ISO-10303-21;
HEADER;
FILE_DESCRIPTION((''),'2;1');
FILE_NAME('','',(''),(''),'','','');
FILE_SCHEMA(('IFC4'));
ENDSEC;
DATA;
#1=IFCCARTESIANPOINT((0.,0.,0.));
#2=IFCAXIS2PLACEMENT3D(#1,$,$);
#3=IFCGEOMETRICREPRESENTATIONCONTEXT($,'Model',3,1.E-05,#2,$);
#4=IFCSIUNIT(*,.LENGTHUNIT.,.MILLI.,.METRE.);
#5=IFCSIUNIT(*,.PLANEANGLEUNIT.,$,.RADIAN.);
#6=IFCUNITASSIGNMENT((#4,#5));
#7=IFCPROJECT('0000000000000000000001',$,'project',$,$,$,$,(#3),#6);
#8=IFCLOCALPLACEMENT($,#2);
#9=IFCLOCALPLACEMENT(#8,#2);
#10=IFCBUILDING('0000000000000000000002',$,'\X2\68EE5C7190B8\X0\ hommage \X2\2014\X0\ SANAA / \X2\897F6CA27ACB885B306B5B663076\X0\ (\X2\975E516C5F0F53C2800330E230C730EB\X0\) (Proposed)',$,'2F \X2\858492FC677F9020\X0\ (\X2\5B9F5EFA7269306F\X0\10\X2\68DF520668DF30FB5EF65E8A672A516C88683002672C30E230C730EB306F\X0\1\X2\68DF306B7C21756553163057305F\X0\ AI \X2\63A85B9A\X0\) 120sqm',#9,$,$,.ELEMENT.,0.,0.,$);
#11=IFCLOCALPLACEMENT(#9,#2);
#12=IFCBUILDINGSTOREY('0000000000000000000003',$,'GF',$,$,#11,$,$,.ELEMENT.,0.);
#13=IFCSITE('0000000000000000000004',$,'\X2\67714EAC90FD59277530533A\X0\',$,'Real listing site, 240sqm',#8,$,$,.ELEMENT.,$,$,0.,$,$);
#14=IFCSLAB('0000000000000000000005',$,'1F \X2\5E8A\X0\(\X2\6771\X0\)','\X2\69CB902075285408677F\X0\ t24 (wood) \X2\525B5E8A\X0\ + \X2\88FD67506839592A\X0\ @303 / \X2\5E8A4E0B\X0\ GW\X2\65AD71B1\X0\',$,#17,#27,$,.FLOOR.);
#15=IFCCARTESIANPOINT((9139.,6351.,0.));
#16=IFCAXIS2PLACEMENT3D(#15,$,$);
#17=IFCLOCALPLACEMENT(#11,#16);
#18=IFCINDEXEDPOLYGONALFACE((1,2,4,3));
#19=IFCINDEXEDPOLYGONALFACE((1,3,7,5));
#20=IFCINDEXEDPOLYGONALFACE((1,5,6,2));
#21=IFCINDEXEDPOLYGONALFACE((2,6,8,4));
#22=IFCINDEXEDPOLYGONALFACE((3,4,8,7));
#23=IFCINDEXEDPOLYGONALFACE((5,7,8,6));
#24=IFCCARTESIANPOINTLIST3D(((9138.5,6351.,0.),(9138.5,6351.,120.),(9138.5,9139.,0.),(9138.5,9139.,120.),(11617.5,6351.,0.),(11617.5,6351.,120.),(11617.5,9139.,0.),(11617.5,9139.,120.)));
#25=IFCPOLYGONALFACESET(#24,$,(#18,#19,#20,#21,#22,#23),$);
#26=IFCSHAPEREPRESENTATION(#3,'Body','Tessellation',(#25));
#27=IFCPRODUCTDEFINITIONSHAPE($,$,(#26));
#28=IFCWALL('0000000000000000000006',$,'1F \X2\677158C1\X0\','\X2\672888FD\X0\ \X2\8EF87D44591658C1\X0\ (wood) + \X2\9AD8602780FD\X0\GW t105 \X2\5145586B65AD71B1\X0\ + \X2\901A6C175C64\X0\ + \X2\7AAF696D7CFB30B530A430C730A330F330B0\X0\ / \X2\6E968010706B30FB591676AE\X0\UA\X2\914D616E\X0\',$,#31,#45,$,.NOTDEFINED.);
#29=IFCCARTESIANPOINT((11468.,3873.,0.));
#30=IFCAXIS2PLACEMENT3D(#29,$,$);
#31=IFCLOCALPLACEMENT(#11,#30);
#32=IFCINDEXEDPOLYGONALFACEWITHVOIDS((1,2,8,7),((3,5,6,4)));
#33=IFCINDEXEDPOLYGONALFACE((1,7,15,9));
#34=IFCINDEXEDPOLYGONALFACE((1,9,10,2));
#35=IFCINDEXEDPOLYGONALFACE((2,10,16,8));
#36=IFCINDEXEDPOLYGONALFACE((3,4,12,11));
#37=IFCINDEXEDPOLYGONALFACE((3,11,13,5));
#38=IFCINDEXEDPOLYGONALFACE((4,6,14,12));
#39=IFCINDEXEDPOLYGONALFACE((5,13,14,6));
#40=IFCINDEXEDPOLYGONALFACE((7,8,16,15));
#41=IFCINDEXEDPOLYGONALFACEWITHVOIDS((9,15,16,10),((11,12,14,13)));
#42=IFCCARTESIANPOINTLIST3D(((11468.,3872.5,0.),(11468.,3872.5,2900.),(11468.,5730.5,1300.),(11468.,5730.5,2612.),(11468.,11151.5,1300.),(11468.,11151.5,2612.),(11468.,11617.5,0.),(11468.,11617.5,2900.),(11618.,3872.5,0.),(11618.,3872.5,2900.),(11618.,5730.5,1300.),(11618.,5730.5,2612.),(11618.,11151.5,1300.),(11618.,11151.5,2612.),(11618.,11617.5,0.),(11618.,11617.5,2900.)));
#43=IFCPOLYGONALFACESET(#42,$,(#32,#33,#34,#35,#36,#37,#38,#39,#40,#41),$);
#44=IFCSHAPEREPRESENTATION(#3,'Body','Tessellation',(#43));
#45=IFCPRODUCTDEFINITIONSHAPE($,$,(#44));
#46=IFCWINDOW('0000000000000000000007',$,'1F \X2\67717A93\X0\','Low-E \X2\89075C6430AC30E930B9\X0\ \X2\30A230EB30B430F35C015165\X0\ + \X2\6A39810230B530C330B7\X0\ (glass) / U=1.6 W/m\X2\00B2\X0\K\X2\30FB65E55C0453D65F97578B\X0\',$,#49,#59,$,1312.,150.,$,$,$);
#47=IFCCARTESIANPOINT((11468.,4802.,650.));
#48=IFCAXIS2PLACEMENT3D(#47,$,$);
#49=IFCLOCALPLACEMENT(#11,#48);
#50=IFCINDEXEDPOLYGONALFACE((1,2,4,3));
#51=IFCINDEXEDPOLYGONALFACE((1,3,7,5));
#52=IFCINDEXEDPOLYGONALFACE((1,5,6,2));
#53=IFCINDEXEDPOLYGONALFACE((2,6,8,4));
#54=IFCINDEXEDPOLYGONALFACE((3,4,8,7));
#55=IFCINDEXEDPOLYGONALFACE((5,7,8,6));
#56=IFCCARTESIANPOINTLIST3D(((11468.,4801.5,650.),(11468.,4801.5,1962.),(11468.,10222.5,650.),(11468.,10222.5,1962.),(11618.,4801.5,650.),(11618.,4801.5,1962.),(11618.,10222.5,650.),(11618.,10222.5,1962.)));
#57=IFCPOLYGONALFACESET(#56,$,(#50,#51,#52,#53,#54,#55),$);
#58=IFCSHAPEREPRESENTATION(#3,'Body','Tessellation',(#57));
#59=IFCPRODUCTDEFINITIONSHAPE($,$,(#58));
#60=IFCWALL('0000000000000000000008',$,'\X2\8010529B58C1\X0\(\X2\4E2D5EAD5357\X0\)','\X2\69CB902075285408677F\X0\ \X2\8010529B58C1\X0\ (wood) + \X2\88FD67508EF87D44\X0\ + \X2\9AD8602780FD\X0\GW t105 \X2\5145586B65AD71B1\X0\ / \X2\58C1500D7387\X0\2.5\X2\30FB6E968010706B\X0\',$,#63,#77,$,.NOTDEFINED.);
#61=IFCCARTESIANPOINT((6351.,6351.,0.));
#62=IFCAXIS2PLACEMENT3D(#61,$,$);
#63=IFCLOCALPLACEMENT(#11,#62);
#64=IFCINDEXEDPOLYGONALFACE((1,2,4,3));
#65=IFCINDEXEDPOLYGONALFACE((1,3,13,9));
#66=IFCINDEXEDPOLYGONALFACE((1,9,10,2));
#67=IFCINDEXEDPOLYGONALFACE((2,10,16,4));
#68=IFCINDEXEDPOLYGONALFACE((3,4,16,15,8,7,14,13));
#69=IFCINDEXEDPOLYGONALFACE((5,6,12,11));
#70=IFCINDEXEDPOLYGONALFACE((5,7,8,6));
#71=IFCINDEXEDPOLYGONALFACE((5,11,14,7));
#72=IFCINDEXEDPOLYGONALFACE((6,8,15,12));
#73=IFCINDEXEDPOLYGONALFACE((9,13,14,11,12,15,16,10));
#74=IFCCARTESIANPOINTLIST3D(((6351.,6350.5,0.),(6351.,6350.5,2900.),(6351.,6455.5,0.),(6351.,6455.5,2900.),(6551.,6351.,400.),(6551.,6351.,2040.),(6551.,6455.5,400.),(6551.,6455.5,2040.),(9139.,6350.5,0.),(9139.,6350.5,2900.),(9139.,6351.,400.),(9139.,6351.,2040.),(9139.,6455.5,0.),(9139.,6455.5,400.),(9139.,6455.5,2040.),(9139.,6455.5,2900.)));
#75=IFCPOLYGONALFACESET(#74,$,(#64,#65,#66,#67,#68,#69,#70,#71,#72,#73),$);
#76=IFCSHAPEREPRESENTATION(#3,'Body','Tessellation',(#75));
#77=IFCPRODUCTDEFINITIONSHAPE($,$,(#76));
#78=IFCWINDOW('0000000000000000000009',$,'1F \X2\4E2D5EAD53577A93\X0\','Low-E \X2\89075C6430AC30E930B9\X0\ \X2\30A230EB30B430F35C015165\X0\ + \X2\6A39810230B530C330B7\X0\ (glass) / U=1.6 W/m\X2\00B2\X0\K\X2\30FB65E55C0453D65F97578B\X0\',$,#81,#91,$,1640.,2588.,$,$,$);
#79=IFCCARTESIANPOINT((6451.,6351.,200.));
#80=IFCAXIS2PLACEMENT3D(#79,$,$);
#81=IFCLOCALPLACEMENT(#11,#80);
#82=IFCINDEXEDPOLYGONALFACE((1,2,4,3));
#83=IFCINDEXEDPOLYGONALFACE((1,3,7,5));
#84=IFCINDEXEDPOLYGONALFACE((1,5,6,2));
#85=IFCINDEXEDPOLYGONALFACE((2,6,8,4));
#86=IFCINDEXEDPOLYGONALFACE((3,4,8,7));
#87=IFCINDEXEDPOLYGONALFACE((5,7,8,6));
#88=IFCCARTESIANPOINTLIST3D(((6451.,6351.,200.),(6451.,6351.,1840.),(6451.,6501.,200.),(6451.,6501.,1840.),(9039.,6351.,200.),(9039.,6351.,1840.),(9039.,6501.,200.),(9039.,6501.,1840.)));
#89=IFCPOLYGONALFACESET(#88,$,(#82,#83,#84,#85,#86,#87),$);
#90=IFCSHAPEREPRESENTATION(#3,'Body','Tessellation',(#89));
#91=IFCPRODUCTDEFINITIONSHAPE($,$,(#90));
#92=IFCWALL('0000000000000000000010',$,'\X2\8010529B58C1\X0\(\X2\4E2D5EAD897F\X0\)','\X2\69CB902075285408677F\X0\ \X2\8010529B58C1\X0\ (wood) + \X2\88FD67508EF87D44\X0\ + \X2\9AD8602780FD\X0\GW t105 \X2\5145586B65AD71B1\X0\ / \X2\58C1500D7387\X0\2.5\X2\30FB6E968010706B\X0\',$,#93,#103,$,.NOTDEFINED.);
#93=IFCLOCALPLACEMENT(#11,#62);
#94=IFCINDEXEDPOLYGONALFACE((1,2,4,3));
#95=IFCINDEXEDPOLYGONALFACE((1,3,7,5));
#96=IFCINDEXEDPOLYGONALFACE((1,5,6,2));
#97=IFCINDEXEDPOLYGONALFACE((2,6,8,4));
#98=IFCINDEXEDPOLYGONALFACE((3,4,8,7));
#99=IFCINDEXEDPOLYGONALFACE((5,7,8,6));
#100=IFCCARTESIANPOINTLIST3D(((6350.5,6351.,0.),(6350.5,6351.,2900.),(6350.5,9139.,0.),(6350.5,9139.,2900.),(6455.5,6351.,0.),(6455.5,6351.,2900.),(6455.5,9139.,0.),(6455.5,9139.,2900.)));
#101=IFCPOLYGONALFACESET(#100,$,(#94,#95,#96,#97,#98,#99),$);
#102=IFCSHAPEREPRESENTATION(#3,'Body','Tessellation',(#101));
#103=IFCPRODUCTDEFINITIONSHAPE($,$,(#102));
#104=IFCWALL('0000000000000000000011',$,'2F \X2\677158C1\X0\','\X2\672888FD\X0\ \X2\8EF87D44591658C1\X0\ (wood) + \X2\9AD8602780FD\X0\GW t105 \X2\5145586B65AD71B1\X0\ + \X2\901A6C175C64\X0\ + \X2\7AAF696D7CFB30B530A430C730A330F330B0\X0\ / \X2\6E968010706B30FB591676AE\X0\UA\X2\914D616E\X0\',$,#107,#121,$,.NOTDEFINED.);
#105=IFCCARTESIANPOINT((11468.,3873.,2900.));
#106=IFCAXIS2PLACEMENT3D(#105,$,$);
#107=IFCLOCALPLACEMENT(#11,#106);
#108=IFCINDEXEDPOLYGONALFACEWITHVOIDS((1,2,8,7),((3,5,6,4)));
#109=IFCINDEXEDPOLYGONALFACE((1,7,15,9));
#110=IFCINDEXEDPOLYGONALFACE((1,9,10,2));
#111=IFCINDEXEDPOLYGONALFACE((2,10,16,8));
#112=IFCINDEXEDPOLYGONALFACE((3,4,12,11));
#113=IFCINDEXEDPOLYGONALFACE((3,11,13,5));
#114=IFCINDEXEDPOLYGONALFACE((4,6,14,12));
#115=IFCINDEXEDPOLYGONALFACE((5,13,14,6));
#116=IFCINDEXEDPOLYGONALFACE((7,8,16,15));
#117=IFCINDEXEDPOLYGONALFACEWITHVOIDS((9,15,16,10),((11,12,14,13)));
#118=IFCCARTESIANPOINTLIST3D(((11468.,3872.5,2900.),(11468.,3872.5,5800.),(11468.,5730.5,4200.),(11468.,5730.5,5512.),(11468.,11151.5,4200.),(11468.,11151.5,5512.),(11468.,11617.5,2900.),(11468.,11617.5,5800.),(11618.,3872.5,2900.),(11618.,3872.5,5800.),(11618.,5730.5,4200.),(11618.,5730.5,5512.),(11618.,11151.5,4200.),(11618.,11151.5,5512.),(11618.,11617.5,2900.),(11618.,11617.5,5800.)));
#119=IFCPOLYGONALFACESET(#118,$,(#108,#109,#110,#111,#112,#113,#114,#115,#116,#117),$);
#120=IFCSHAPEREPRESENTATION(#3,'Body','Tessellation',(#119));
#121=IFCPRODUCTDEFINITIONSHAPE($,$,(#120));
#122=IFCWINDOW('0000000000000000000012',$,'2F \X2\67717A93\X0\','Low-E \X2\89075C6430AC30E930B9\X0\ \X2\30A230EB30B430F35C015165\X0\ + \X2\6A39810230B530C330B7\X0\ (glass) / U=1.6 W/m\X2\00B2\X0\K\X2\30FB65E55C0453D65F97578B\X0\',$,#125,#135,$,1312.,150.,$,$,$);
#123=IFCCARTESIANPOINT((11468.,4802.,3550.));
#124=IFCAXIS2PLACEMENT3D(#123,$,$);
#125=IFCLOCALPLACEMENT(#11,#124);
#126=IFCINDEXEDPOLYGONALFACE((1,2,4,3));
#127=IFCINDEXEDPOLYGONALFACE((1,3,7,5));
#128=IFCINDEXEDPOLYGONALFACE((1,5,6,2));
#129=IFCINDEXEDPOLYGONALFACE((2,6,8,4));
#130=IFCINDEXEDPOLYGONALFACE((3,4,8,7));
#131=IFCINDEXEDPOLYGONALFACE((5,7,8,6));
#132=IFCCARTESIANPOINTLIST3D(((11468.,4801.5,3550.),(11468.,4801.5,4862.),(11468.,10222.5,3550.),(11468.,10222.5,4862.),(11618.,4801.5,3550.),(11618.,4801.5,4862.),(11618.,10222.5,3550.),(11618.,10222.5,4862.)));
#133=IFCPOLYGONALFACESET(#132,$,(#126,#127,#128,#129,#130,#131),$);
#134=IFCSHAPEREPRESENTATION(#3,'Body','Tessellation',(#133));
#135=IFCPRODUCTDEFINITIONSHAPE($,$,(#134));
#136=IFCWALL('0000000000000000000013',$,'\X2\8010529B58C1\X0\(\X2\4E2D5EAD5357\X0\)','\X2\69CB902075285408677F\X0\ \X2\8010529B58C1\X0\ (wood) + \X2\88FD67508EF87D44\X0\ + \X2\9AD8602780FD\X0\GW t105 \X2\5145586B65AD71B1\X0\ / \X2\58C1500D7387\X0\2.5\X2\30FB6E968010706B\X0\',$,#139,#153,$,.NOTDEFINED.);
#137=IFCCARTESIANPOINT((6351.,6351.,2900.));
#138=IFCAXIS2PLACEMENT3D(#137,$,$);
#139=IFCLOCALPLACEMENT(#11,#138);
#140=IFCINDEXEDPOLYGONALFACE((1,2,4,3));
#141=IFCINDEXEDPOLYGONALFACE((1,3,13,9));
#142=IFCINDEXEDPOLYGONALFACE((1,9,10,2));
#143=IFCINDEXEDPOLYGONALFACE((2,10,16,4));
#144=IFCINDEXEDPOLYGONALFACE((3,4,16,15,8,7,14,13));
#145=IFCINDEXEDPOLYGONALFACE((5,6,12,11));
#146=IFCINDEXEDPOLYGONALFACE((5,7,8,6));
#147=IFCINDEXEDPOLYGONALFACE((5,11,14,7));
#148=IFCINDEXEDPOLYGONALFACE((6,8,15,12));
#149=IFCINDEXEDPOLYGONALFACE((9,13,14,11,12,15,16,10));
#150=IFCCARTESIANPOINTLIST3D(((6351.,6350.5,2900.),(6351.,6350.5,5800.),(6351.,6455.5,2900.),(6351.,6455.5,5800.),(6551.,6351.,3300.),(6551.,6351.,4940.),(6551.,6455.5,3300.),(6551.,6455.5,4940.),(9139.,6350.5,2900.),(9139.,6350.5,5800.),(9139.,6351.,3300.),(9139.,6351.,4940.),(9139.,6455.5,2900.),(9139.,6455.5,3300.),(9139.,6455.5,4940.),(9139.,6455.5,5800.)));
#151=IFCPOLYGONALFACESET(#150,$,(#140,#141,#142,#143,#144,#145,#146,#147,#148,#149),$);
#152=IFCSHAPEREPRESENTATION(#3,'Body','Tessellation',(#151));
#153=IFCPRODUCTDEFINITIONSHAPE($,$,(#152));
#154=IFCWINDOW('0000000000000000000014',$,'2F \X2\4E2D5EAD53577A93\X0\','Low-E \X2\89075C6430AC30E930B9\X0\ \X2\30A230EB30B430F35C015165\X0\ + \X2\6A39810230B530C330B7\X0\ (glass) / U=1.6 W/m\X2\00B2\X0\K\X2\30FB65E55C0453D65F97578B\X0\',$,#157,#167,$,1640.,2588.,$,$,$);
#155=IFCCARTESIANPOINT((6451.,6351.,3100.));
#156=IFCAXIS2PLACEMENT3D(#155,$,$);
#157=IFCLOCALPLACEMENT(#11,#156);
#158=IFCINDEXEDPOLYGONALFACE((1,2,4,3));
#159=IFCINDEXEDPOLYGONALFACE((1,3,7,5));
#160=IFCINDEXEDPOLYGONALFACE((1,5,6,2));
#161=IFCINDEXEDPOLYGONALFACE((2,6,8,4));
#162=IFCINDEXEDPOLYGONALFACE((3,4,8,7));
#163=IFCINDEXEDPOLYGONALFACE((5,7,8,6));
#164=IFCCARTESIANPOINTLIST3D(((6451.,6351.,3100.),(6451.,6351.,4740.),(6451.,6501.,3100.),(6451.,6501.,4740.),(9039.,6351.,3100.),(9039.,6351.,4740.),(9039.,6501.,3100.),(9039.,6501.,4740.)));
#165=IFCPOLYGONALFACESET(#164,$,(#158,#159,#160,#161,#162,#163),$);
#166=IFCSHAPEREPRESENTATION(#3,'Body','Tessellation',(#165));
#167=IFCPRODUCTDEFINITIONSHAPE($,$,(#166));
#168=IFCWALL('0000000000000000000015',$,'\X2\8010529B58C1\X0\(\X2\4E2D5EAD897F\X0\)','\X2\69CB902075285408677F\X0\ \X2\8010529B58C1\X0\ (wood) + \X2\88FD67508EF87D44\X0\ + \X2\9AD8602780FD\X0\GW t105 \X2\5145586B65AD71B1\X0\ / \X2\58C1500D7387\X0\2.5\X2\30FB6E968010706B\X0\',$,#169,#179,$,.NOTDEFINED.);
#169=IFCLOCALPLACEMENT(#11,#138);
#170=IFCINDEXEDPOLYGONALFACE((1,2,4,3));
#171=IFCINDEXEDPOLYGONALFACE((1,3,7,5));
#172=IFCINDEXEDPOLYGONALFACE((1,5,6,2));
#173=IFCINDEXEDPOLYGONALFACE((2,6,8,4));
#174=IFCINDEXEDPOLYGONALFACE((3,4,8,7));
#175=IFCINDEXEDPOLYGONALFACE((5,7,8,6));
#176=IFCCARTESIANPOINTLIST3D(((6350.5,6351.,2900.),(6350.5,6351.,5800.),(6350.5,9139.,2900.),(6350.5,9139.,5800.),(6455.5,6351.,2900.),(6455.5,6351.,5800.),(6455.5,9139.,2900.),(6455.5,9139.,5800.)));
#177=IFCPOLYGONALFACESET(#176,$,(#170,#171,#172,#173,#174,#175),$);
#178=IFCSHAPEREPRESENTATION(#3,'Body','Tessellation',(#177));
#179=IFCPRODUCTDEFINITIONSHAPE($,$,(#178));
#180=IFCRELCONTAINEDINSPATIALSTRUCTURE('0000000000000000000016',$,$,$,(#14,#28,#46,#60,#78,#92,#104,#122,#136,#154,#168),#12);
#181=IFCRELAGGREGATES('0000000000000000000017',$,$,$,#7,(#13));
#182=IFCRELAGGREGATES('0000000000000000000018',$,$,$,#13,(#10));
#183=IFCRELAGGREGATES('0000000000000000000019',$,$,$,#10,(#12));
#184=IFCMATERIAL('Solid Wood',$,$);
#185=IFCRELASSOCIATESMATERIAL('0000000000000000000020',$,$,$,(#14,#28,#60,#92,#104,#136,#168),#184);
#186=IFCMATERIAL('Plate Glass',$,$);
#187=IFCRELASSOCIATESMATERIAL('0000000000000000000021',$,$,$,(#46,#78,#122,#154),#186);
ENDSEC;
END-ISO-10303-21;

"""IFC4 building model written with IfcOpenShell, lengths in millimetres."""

from ifc_helpers import new_model, si_unit, frame, frame_2d, origin, place, context, project, spatial, rectangle, extrude, material, element, fill, save


model = new_model("IFC4")

# Units and contexts
model_context = context("Model", 3, precision=1e-05, world=origin())
ifc_project = project(units=[si_unit("LENGTHUNIT", "METRE", prefix="MILLI"), si_unit("PLANEANGLEUNIT", "RADIAN")], contexts=[model_context])

# Site, building, storey
site_placement = place(None, origin())
site = spatial("IfcSite", under=ifc_project, at=site_placement, Name="東京都大田区", ObjectType="Real listing site, 240sqm", CompositionType="ELEMENT", RefElevation=0.0)
building_placement = place(site_placement, origin())
building = spatial("IfcBuilding", under=site, at=building_placement, Name="森山邸 hommage — SANAA / 西沢立衛に学ぶ (非公式参考モデル) (Proposed)", ObjectType="2F 薄鋼板造 (実建物は10棟分棟・延床未公表。本モデルは1棟に簡略化した AI 推定) 120sqm", CompositionType="ELEMENT", ElevationOfRefHeight=0.0, ElevationOfTerrain=0.0)
storey_placement = place(building_placement, origin())
storey = spatial("IfcBuildingStorey", under=building, at=storey_placement, Name="GF", CompositionType="ELEMENT", Elevation=0.0)

# Slab
ifc_material_1 = material(Name="Solid Wood")
slab_placement = place(storey_placement, frame((9139.0, 6351.0, 0.0)))
element("IfcSlab", 1, at=slab_placement, inside=storey, material=ifc_material_1, Name="1F 床(東)", Description="構造用合板 t24 (wood) 剛床 + 製材根太 @303 / 床下 GW断熱", PredefinedType="FLOOR", context=model_context, shape_type="SweptSolid", body=[
    extrude(rectangle(XDim=2479.0, YDim=2788.0, at=frame_2d((1239.0, 1394.0))), frame((9139.0, 6351.0, 0.0)), (0.0, 0.0, 1.0), 120.0),
])

# Walls, openings, windows
wall_1_placement = place(storey_placement, frame((11468.0, 3873.0, 0.0)))
wall_1 = element("IfcWall", 2, at=wall_1_placement, inside=storey, material=ifc_material_1, Name="1F 東壁", Description="木製 軸組外壁 (wood) + 高性能GW t105 充填断熱 + 通気層 + 窯業系サイディング / 準耐火・外皮UA配慮", PredefinedType="NOTDEFINED", context=model_context, shape_type="SweptSolid", body=[
    extrude(rectangle(XDim=150.0, YDim=7745.0, at=frame_2d((75.0, 3872.0))), frame((11468.0, 3873.0, 0.0)), (0.0, 0.0, 1.0), 2900.0),
])
opening_1_placement = place(storey_placement, frame((11468.0, 4802.0, 650.0)))
opening_1 = element("IfcOpeningElement", 3, at=opening_1_placement, cuts=wall_1, PredefinedType="NOTDEFINED", context=model_context, shape_type="SweptSolid", body=[
    extrude(rectangle(XDim=150.0, YDim=5421.0, at=frame_2d((75.0, 2710.0))), frame((11468.0, 4802.0, 650.0)), (0.0, 0.0, 1.0), 1312.0),
])
ifc_material_2 = material(Name="Plate Glass")
window_1_placement = place(storey_placement, frame((11468.0, 4802.0, 650.0)))
window_1 = element("IfcWindow", 4, at=window_1_placement, inside=storey, material=ifc_material_2, Name="1F 東窓", Description="Low-E 複層ガラス アルゴン封入 + 樹脂サッシ (glass) / U=1.6 W/m²K・日射取得型", OverallHeight=1312.0, OverallWidth=150.0, context=model_context, shape_type="SweptSolid", body=[
    extrude(rectangle(XDim=150.0, YDim=5421.0, at=frame_2d((75.0, 2710.0))), frame((11468.0, 4802.0, 650.0)), (0.0, 0.0, 1.0), 1312.0),
])
fill(opening_1, window_1)
wall_2_placement = place(storey_placement, frame((6351.0, 6351.0, 0.0)))
wall_2 = element("IfcWall", 5, at=wall_2_placement, inside=storey, material=ifc_material_1, Name="耐力壁(中庭南)", Description="構造用合板 耐力壁 (wood) + 製材軸組 + 高性能GW t105 充填断熱 / 壁倍率2.5・準耐火", PredefinedType="NOTDEFINED", context=model_context, shape_type="SweptSolid", body=[
    extrude(rectangle(XDim=2788.0, YDim=105.0, at=frame_2d((1394.0, 52.0))), frame((6351.0, 6351.0, 0.0)), (0.0, 0.0, 1.0), 2900.0),
])
opening_2_placement = place(storey_placement, frame((6451.0, 6351.0, 200.0)))
opening_2 = element("IfcOpeningElement", 6, at=opening_2_placement, cuts=wall_2, PredefinedType="NOTDEFINED", context=model_context, shape_type="SweptSolid", body=[
    extrude(rectangle(XDim=2588.0, YDim=150.0, at=frame_2d((1294.0, 75.0))), frame((6451.0, 6351.0, 200.0)), (0.0, 0.0, 1.0), 1640.0),
])
window_2_placement = place(storey_placement, frame((6451.0, 6351.0, 200.0)))
window_2 = element("IfcWindow", 7, at=window_2_placement, inside=storey, material=ifc_material_2, Name="1F 中庭南窓", Description="Low-E 複層ガラス アルゴン封入 + 樹脂サッシ (glass) / U=1.6 W/m²K・日射取得型", OverallHeight=1640.0, OverallWidth=2588.0, context=model_context, shape_type="SweptSolid", body=[
    extrude(rectangle(XDim=2588.0, YDim=150.0, at=frame_2d((1294.0, 75.0))), frame((6451.0, 6351.0, 200.0)), (0.0, 0.0, 1.0), 1640.0),
])
fill(opening_2, window_2)

# Wall
wall_3_placement = place(storey_placement, frame((6351.0, 6351.0, 0.0)))
element("IfcWall", 8, at=wall_3_placement, inside=storey, material=ifc_material_1, Name="耐力壁(中庭西)", Description="構造用合板 耐力壁 (wood) + 製材軸組 + 高性能GW t105 充填断熱 / 壁倍率2.5・準耐火", PredefinedType="NOTDEFINED", context=model_context, shape_type="SweptSolid", body=[
    extrude(rectangle(XDim=105.0, YDim=2788.0, at=frame_2d((52.0, 1394.0))), frame((6351.0, 6351.0, 0.0)), (0.0, 0.0, 1.0), 2900.0),
])

# Walls, openings, windows
wall_4_placement = place(storey_placement, frame((11468.0, 3873.0, 2900.0)))
wall_4 = element("IfcWall", 9, at=wall_4_placement, inside=storey, material=ifc_material_1, Name="2F 東壁", Description="木製 軸組外壁 (wood) + 高性能GW t105 充填断熱 + 通気層 + 窯業系サイディング / 準耐火・外皮UA配慮", PredefinedType="NOTDEFINED", context=model_context, shape_type="SweptSolid", body=[
    extrude(rectangle(XDim=150.0, YDim=7745.0, at=frame_2d((75.0, 3872.0))), frame((11468.0, 3873.0, 2900.0)), (0.0, 0.0, 1.0), 2900.0),
])
opening_3_placement = place(storey_placement, frame((11468.0, 4802.0, 3550.0)))
opening_3 = element("IfcOpeningElement", 10, at=opening_3_placement, cuts=wall_4, PredefinedType="NOTDEFINED", context=model_context, shape_type="SweptSolid", body=[
    extrude(rectangle(XDim=150.0, YDim=5421.0, at=frame_2d((75.0, 2710.0))), frame((11468.0, 4802.0, 3550.0)), (0.0, 0.0, 1.0), 1312.0),
])
window_3_placement = place(storey_placement, frame((11468.0, 4802.0, 3550.0)))
window_3 = element("IfcWindow", 11, at=window_3_placement, inside=storey, material=ifc_material_2, Name="2F 東窓", Description="Low-E 複層ガラス アルゴン封入 + 樹脂サッシ (glass) / U=1.6 W/m²K・日射取得型", OverallHeight=1312.0, OverallWidth=150.0, context=model_context, shape_type="SweptSolid", body=[
    extrude(rectangle(XDim=150.0, YDim=5421.0, at=frame_2d((75.0, 2710.0))), frame((11468.0, 4802.0, 3550.0)), (0.0, 0.0, 1.0), 1312.0),
])
fill(opening_3, window_3)
wall_5_placement = place(storey_placement, frame((6351.0, 6351.0, 2900.0)))
wall_5 = element("IfcWall", 12, at=wall_5_placement, inside=storey, material=ifc_material_1, Name="耐力壁(中庭南)", Description="構造用合板 耐力壁 (wood) + 製材軸組 + 高性能GW t105 充填断熱 / 壁倍率2.5・準耐火", PredefinedType="NOTDEFINED", context=model_context, shape_type="SweptSolid", body=[
    extrude(rectangle(XDim=2788.0, YDim=105.0, at=frame_2d((1394.0, 52.0))), frame((6351.0, 6351.0, 2900.0)), (0.0, 0.0, 1.0), 2900.0),
])
opening_4_placement = place(storey_placement, frame((6451.0, 6351.0, 3100.0)))
opening_4 = element("IfcOpeningElement", 13, at=opening_4_placement, cuts=wall_5, PredefinedType="NOTDEFINED", context=model_context, shape_type="SweptSolid", body=[
    extrude(rectangle(XDim=2588.0, YDim=150.0, at=frame_2d((1294.0, 75.0))), frame((6451.0, 6351.0, 3100.0)), (0.0, 0.0, 1.0), 1640.0),
])
window_4_placement = place(storey_placement, frame((6451.0, 6351.0, 3100.0)))
window_4 = element("IfcWindow", 14, at=window_4_placement, inside=storey, material=ifc_material_2, Name="2F 中庭南窓", Description="Low-E 複層ガラス アルゴン封入 + 樹脂サッシ (glass) / U=1.6 W/m²K・日射取得型", OverallHeight=1640.0, OverallWidth=2588.0, context=model_context, shape_type="SweptSolid", body=[
    extrude(rectangle(XDim=2588.0, YDim=150.0, at=frame_2d((1294.0, 75.0))), frame((6451.0, 6351.0, 3100.0)), (0.0, 0.0, 1.0), 1640.0),
])
fill(opening_4, window_4)

# Wall
wall_6_placement = place(storey_placement, frame((6351.0, 6351.0, 2900.0)))
element("IfcWall", 15, at=wall_6_placement, inside=storey, material=ifc_material_1, Name="耐力壁(中庭西)", Description="構造用合板 耐力壁 (wood) + 製材軸組 + 高性能GW t105 充填断熱 / 壁倍率2.5・準耐火", PredefinedType="NOTDEFINED", context=model_context, shape_type="SweptSolid", body=[
    extrude(rectangle(XDim=105.0, YDim=2788.0, at=frame_2d((52.0, 1394.0))), frame((6351.0, 6351.0, 2900.0)), (0.0, 0.0, 1.0), 2900.0),
])

save(model, "model.ifc")
